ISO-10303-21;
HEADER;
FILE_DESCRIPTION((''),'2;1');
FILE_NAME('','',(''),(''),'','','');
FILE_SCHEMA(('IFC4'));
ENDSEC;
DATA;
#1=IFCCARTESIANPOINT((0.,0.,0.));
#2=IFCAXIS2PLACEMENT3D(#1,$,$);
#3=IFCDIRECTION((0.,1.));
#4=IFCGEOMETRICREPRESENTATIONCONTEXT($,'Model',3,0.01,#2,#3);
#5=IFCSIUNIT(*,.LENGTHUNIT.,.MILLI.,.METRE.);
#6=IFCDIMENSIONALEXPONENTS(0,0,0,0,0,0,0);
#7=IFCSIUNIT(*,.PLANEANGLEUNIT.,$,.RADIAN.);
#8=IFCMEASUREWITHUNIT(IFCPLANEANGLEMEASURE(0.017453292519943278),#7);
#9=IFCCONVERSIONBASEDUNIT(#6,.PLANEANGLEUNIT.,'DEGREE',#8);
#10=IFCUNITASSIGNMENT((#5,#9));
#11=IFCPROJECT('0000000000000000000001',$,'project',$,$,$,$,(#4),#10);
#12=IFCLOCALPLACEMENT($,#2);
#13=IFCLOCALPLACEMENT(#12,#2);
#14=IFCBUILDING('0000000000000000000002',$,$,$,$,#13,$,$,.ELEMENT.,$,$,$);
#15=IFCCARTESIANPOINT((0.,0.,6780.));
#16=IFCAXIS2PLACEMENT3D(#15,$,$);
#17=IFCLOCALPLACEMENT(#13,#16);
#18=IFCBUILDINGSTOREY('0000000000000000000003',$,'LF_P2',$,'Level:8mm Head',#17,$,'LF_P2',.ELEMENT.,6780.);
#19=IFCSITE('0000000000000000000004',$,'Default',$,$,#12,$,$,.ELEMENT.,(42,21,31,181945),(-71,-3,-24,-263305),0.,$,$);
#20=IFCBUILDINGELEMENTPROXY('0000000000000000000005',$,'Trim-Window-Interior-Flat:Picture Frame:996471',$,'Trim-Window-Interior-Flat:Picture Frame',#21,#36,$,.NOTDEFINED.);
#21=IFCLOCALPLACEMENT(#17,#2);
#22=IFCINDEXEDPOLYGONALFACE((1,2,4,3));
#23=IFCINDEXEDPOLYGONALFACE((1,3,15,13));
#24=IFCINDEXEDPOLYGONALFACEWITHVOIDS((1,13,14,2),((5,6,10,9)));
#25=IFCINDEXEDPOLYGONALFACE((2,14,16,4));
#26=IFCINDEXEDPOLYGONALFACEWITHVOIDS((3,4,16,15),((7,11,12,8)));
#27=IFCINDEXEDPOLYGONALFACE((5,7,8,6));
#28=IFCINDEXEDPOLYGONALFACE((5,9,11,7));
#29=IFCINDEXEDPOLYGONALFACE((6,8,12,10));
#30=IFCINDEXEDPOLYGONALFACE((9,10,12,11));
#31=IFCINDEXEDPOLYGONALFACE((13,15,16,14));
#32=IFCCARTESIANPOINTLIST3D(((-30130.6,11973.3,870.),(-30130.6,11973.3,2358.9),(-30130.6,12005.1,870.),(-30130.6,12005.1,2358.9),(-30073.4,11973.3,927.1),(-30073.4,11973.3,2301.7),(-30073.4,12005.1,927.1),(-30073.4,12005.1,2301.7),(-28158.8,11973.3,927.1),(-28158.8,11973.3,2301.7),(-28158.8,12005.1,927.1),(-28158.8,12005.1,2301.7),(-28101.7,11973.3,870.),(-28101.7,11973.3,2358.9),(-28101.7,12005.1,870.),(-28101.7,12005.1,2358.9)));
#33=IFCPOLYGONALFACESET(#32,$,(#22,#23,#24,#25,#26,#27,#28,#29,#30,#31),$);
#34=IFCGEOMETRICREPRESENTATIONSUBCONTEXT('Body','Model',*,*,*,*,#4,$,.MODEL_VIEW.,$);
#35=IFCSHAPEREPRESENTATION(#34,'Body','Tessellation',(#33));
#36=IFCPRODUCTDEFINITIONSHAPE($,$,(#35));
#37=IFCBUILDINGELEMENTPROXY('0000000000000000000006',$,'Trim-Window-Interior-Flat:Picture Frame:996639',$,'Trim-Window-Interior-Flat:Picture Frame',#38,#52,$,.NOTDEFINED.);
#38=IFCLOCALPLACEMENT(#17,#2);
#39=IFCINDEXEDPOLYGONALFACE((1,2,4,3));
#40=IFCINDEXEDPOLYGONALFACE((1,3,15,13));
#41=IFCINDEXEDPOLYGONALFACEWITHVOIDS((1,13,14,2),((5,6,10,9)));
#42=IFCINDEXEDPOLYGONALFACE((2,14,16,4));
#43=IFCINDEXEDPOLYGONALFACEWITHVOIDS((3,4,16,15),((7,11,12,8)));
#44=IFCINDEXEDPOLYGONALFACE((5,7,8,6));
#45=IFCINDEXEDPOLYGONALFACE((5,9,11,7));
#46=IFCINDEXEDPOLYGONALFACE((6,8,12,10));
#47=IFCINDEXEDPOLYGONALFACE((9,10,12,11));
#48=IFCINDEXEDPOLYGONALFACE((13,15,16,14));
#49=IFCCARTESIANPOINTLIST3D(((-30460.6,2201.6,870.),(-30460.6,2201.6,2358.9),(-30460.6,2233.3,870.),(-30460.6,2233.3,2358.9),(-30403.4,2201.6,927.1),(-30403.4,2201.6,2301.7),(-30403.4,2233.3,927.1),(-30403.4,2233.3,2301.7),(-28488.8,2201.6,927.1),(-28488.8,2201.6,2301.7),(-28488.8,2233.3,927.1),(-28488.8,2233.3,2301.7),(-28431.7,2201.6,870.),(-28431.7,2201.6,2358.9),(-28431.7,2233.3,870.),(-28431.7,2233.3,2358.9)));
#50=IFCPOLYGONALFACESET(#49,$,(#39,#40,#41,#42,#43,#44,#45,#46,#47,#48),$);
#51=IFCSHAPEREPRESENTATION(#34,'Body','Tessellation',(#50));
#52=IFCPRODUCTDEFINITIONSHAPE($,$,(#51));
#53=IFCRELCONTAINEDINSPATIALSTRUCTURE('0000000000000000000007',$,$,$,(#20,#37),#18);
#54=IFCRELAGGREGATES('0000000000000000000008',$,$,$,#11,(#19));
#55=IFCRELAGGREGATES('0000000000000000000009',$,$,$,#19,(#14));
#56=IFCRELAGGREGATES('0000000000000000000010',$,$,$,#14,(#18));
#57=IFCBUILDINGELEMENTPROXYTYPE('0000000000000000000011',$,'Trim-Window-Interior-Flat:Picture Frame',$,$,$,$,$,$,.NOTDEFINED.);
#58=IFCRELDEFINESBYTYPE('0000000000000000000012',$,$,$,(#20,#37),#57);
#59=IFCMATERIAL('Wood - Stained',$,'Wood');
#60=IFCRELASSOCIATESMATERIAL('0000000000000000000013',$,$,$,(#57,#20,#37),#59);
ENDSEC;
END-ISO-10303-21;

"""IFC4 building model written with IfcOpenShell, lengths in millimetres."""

from ifc_helpers import new_model, entity, si_unit, converted_unit, direction, frame, origin, place, context, subcontext, project, spatial, indexed_curve, outline, extrude, source, transform, mapped, material, type_object, type_shapes, element, save


model = new_model("IFC4")

# Units and contexts
model_context = context("Model", 3, precision=0.01, world=origin(), true_north=direction((0.0, 1.0)))
body_context = subcontext(model_context, "Body", "Model", "MODEL_VIEW")
ifc_project = project(units=[si_unit("LENGTHUNIT", "METRE", prefix="MILLI"), converted_unit("PLANEANGLEUNIT", "DEGREE", entity("IfcPlaneAngleMeasure", 0.017453292519943278), si_unit("PLANEANGLEUNIT", "RADIAN"), dimensions=[0, 0, 0, 0, 0, 0, 0])], contexts=[model_context])

# Site, building, storey
site_placement = place(None, origin())
site = spatial("IfcSite", under=ifc_project, at=site_placement, Name="Default", CompositionType="ELEMENT", RefLatitude=(42, 21, 31, 181945), RefLongitude=(-71, -3, -24, -263305), RefElevation=0.0)
building_placement = place(site_placement, origin())
building = spatial("IfcBuilding", under=site, at=building_placement, CompositionType="ELEMENT")
storey_placement = place(building_placement, frame((0.0, 0.0, 6780.0)))
storey = spatial("IfcBuildingStorey", under=building, at=storey_placement, Name="LF_P2", ObjectType="Level:8mm Head", LongName="LF_P2", CompositionType="ELEMENT", Elevation=6780.0)

# Building element proxies
ifc_material_1 = material(Name="Wood - Stained", Category="Wood")
building_element_proxy_type_1 = type_object("IfcBuildingElementProxyType", Name="Trim-Window-Interior-Flat:Picture Frame", PredefinedType="NOTDEFINED", material=ifc_material_1)
shared_shape_1 = source(origin(), body_context, "Body", "SweptSolid", [
    extrude(outline(indexed_curve([(-1014.4, -744.4), (1014.4, -744.4), (1014.4, 744.4), (-1014.4, 744.4), (-1014.4, -744.4)], self_intersect=False), holes=[indexed_curve([(-957.3, -687.3), (-957.3, 687.3), (957.3, 687.3), (957.3, -687.3), (-957.3, -687.3)], self_intersect=False)]), frame((0.0, -700.0, 0.0), z_axis=(0.0, 0.0, 1.0), x_axis=(-1.0, 0.0, 0.0)), (0.0, 0.0, 1.0), 31.7),
])
type_shapes(building_element_proxy_type_1, [shared_shape_1])
for number, where, z_axis, x_axis, name in (
    (1, (-29116.1, 11973.3, 2314.4), (0.0, 1.0, 0.0), (-1.0, 0.0, 0.0), "Trim-Window-Interior-Flat:Picture Frame:996471"),
    (2, (-29446.1, 2233.3, 2314.4), (0.0, -1.0, 0.0), (1.0, 0.0, 0.0), "Trim-Window-Interior-Flat:Picture Frame:996639"),
):
    element("IfcBuildingElementProxy", number, at=place(storey_placement, frame(where, z_axis=z_axis, x_axis=x_axis)), inside=storey, type_object=building_element_proxy_type_1, material=ifc_material_1, Name=name, ObjectType="Trim-Window-Interior-Flat:Picture Frame", PredefinedType="NOTDEFINED", context=body_context, shape_type="MappedRepresentation", body=[
        mapped(shared_shape_1, transform((0.0, 0.0, 0.0), scale=1.0)),
    ])

save(model, "model.ifc")
